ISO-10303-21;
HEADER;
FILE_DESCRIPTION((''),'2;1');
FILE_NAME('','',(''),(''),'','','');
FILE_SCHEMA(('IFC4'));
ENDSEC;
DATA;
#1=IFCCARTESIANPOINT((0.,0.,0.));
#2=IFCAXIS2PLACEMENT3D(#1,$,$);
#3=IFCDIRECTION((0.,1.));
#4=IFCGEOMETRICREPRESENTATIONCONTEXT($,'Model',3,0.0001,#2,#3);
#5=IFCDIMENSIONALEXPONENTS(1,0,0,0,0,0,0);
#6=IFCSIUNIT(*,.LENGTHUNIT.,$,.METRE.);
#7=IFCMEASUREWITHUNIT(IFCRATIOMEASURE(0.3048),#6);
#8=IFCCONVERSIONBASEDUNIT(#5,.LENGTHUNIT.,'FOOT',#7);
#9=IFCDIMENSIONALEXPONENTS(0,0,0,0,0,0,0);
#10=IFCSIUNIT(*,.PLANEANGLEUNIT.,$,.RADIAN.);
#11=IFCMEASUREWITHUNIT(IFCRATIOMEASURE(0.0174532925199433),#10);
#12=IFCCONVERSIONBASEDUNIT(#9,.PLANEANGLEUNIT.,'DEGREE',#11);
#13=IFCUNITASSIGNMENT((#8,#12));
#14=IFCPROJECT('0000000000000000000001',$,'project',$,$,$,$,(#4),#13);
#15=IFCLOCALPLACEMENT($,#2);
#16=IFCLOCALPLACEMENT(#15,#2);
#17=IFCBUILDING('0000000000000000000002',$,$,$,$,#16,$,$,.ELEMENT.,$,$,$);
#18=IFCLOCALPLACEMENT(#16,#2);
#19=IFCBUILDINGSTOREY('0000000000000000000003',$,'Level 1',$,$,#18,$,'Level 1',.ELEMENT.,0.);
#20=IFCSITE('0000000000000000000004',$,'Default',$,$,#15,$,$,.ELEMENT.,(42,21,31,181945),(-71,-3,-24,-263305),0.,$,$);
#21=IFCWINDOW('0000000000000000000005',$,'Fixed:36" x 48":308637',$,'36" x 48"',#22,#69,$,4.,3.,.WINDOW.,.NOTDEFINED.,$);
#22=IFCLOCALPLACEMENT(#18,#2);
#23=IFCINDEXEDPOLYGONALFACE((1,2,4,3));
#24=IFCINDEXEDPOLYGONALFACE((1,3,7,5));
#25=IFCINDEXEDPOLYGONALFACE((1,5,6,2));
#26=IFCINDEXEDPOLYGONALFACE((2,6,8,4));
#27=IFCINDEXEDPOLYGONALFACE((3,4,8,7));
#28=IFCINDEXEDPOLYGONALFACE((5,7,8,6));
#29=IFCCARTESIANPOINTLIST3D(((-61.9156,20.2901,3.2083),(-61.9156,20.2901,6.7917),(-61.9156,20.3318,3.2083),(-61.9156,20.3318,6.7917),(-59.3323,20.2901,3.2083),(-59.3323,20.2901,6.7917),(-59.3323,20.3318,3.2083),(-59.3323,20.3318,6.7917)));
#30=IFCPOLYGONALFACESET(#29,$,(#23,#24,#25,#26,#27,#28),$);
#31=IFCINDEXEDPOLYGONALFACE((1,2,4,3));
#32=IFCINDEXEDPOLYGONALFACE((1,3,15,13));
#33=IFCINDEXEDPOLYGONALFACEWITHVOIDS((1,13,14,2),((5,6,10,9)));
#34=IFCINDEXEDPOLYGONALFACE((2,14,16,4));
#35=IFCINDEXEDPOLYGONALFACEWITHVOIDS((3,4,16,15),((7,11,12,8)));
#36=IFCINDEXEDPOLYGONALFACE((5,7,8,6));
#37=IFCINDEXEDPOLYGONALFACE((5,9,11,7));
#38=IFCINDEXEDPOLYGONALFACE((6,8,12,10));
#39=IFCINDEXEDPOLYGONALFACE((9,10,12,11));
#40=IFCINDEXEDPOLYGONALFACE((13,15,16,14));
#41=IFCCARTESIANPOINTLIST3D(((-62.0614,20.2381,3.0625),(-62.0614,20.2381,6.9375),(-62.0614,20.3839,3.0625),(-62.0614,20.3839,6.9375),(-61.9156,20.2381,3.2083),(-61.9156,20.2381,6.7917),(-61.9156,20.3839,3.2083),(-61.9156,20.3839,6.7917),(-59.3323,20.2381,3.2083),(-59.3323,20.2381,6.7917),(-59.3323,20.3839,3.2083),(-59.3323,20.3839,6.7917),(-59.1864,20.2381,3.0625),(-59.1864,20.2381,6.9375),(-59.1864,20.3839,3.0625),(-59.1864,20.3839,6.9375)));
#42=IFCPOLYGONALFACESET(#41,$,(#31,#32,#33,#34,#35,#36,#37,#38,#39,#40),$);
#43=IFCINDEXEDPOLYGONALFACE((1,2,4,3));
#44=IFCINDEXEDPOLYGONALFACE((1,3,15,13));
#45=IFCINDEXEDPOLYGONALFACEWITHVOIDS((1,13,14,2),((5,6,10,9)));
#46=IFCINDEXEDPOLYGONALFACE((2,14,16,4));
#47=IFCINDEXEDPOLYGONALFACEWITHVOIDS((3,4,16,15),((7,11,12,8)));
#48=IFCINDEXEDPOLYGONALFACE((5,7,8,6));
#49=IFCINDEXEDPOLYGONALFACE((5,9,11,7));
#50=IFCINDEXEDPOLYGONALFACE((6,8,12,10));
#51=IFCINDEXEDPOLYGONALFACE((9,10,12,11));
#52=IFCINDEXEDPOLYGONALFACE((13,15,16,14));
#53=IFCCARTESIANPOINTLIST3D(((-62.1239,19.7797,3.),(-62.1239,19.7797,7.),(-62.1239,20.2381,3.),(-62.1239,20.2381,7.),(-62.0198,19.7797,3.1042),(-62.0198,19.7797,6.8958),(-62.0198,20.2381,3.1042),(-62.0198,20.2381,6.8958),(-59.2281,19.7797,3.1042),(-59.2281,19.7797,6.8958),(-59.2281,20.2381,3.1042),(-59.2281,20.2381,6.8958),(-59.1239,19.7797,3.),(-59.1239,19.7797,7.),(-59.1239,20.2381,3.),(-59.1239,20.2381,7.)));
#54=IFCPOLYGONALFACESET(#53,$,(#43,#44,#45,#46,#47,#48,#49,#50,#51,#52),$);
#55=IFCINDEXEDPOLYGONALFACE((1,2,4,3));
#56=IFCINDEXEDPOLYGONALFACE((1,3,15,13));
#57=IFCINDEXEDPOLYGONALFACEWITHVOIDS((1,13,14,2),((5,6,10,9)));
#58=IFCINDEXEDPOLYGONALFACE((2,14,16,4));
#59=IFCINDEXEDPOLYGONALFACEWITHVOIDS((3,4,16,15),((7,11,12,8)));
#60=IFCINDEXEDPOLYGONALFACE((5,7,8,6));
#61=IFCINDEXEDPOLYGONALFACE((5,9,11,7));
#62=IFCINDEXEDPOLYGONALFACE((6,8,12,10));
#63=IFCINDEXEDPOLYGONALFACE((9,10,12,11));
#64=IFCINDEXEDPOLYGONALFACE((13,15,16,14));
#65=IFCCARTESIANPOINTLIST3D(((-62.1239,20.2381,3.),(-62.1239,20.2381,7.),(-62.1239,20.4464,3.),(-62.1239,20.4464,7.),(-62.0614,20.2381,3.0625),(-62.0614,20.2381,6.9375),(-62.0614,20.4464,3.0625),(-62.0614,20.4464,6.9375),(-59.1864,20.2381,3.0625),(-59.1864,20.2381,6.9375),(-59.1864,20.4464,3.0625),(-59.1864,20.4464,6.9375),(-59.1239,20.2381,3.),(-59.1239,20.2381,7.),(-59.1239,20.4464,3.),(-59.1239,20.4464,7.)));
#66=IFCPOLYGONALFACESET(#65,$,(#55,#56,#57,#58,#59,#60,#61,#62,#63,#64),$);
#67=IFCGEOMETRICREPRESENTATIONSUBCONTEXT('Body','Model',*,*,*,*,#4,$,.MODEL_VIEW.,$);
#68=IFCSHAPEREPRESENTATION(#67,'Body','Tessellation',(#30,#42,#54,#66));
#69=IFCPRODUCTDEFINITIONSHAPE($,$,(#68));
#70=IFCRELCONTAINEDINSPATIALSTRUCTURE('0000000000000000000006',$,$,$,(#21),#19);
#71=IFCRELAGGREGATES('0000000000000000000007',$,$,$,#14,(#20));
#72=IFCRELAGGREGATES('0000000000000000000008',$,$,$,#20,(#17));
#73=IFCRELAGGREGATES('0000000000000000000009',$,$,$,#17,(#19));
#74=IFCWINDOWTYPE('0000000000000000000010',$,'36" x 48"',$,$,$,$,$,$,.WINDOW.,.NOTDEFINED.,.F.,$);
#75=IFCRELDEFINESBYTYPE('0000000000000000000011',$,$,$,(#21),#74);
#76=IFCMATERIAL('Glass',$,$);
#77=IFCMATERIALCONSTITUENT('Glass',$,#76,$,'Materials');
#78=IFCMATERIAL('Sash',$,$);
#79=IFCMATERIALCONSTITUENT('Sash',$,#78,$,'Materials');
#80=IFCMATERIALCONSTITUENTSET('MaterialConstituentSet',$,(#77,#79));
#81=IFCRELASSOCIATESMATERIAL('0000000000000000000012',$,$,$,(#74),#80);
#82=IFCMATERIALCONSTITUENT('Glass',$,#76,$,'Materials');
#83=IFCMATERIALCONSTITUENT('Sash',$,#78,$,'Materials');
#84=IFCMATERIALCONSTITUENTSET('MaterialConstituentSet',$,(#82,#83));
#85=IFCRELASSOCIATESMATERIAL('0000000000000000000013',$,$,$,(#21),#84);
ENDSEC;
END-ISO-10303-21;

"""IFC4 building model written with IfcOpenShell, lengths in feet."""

from ifc_helpers import new_model, entity, si_unit, converted_unit, direction, frame, frame_2d, origin, place, context, subcontext, project, spatial, polyline, rectangle, outline, extrude, source, transform, mapped, material, constituent, constituent_set, type_object, type_shapes, element, save


model = new_model("IFC4")

# Units and contexts
model_context = context("Model", 3, precision=0.0001, world=origin(), true_north=direction((0.0, 1.0)))
body_context = subcontext(model_context, "Body", "Model", "MODEL_VIEW")
ifc_project = project(units=[converted_unit("LENGTHUNIT", "FOOT", entity("IfcRatioMeasure", 0.3048), si_unit("LENGTHUNIT", "METRE"), dimensions=[1, 0, 0, 0, 0, 0, 0]), converted_unit("PLANEANGLEUNIT", "DEGREE", entity("IfcRatioMeasure", 0.0174532925199433), si_unit("PLANEANGLEUNIT", "RADIAN"), dimensions=[0, 0, 0, 0, 0, 0, 0])], contexts=[model_context])

# Site, building, storey
site_placement = place(None, origin())
site = spatial("IfcSite", under=ifc_project, at=site_placement, Name="Default", CompositionType="ELEMENT", RefLatitude=(42, 21, 31, 181945), RefLongitude=(-71, -3, -24, -263305), RefElevation=0.0)
building_placement = place(site_placement, origin())
building = spatial("IfcBuilding", under=site, at=building_placement, CompositionType="ELEMENT")
storey_placement = place(building_placement, origin())
storey = spatial("IfcBuildingStorey", under=building, at=storey_placement, Name="Level 1", LongName="Level 1", CompositionType="ELEMENT", Elevation=0.0)

# Shared definitions
placement_1 = place(storey_placement, frame((-69.2906, 20.1131, 0.0)))

# Window
ifc_material_1 = material(Name="Glass")
ifc_constituent_1 = constituent(ifc_material_1, Name="Glass", Category="Materials")
ifc_material_2 = material(Name="Sash")
ifc_constituent_2 = constituent(ifc_material_2, Name="Sash", Category="Materials")
ifc_constituent_set_1 = constituent_set(constituents=[ifc_constituent_1, ifc_constituent_2], Name="MaterialConstituentSet")
ifc_constituent_3 = constituent(ifc_material_1, Name="Glass", Category="Materials")
ifc_constituent_4 = constituent(ifc_material_2, Name="Sash", Category="Materials")
ifc_constituent_set_2 = constituent_set(constituents=[ifc_constituent_3, ifc_constituent_4], Name="MaterialConstituentSet")
window_type = type_object("IfcWindowType", Name="36\" x 48\"", ParameterTakesPrecedence=False, PartitioningType="NOTDEFINED", PredefinedType="WINDOW", material=ifc_constituent_set_2)
shared_shape = source(origin(), body_context, "Body", "SweptSolid", [
    extrude(rectangle(XDim=0.0417, YDim=2.5833, at=frame_2d((0.0, 0.0), x_axis=(1.0, 0.0))), frame((1.5, 0.5312, 0.2083), z_axis=(0.0, 0.0, 1.0), x_axis=(0.0, 1.0, 0.0)), (0.0, 0.0, 1.0), 3.5833),
    extrude(outline(polyline([(-1.4375, -1.9375), (1.4375, -1.9375), (1.4375, 1.9375), (-1.4375, 1.9375), (-1.4375, -1.9375)]), holes=[polyline([(-1.2917, -1.7917), (-1.2917, 1.7917), (1.2917, 1.7917), (1.2917, -1.7917), (-1.2917, -1.7917)])]), frame((1.5, 0.4583, 2.0), z_axis=(0.0, 1.0, 0.0), x_axis=(1.0, 0.0, 0.0)), (0.0, 0.0, 1.0), 0.1458),
    extrude(outline(polyline([(-1.5, -2.0), (1.5, -2.0), (1.5, 2.0), (-1.5, 2.0), (-1.5, -2.0)]), holes=[polyline([(-1.3958, -1.8958), (-1.3958, 1.8958), (1.3958, 1.8958), (1.3958, -1.8958), (-1.3958, -1.8958)])]), frame((1.5, 0.0, 2.0), z_axis=(0.0, 1.0, 0.0), x_axis=(1.0, 0.0, 0.0)), (0.0, 0.0, 1.0), 0.4583),
    extrude(outline(polyline([(-2.0, -1.5), (2.0, -1.5), (2.0, 1.5), (-2.0, 1.5), (-2.0, -1.5)]), holes=[polyline([(-1.9375, -1.4375), (-1.9375, 1.4375), (1.9375, 1.4375), (1.9375, -1.4375), (-1.9375, -1.4375)])]), frame((1.5, 0.4583, 2.0), z_axis=(0.0, 1.0, 0.0), x_axis=(0.0, 0.0, -1.0)), (0.0, 0.0, 1.0), 0.2083),
])
type_shapes(window_type, [shared_shape])
placement_2 = place(placement_1, frame((7.1667, -0.3333, 3.0)))
window_placement = place(placement_2, origin())
element("IfcWindow", 1, at=window_placement, inside=storey, type_object=window_type, material=ifc_constituent_set_1, Name="Fixed:36\" x 48\":308637", ObjectType="36\" x 48\"", OverallHeight=4.0, OverallWidth=3.0, PartitioningType="NOTDEFINED", PredefinedType="WINDOW", context=body_context, shape_type="MappedRepresentation", body=[
    mapped(shared_shape, transform((0.0, 0.0, 0.0), scale=1.0)),
])

save(model, "model.ifc")
